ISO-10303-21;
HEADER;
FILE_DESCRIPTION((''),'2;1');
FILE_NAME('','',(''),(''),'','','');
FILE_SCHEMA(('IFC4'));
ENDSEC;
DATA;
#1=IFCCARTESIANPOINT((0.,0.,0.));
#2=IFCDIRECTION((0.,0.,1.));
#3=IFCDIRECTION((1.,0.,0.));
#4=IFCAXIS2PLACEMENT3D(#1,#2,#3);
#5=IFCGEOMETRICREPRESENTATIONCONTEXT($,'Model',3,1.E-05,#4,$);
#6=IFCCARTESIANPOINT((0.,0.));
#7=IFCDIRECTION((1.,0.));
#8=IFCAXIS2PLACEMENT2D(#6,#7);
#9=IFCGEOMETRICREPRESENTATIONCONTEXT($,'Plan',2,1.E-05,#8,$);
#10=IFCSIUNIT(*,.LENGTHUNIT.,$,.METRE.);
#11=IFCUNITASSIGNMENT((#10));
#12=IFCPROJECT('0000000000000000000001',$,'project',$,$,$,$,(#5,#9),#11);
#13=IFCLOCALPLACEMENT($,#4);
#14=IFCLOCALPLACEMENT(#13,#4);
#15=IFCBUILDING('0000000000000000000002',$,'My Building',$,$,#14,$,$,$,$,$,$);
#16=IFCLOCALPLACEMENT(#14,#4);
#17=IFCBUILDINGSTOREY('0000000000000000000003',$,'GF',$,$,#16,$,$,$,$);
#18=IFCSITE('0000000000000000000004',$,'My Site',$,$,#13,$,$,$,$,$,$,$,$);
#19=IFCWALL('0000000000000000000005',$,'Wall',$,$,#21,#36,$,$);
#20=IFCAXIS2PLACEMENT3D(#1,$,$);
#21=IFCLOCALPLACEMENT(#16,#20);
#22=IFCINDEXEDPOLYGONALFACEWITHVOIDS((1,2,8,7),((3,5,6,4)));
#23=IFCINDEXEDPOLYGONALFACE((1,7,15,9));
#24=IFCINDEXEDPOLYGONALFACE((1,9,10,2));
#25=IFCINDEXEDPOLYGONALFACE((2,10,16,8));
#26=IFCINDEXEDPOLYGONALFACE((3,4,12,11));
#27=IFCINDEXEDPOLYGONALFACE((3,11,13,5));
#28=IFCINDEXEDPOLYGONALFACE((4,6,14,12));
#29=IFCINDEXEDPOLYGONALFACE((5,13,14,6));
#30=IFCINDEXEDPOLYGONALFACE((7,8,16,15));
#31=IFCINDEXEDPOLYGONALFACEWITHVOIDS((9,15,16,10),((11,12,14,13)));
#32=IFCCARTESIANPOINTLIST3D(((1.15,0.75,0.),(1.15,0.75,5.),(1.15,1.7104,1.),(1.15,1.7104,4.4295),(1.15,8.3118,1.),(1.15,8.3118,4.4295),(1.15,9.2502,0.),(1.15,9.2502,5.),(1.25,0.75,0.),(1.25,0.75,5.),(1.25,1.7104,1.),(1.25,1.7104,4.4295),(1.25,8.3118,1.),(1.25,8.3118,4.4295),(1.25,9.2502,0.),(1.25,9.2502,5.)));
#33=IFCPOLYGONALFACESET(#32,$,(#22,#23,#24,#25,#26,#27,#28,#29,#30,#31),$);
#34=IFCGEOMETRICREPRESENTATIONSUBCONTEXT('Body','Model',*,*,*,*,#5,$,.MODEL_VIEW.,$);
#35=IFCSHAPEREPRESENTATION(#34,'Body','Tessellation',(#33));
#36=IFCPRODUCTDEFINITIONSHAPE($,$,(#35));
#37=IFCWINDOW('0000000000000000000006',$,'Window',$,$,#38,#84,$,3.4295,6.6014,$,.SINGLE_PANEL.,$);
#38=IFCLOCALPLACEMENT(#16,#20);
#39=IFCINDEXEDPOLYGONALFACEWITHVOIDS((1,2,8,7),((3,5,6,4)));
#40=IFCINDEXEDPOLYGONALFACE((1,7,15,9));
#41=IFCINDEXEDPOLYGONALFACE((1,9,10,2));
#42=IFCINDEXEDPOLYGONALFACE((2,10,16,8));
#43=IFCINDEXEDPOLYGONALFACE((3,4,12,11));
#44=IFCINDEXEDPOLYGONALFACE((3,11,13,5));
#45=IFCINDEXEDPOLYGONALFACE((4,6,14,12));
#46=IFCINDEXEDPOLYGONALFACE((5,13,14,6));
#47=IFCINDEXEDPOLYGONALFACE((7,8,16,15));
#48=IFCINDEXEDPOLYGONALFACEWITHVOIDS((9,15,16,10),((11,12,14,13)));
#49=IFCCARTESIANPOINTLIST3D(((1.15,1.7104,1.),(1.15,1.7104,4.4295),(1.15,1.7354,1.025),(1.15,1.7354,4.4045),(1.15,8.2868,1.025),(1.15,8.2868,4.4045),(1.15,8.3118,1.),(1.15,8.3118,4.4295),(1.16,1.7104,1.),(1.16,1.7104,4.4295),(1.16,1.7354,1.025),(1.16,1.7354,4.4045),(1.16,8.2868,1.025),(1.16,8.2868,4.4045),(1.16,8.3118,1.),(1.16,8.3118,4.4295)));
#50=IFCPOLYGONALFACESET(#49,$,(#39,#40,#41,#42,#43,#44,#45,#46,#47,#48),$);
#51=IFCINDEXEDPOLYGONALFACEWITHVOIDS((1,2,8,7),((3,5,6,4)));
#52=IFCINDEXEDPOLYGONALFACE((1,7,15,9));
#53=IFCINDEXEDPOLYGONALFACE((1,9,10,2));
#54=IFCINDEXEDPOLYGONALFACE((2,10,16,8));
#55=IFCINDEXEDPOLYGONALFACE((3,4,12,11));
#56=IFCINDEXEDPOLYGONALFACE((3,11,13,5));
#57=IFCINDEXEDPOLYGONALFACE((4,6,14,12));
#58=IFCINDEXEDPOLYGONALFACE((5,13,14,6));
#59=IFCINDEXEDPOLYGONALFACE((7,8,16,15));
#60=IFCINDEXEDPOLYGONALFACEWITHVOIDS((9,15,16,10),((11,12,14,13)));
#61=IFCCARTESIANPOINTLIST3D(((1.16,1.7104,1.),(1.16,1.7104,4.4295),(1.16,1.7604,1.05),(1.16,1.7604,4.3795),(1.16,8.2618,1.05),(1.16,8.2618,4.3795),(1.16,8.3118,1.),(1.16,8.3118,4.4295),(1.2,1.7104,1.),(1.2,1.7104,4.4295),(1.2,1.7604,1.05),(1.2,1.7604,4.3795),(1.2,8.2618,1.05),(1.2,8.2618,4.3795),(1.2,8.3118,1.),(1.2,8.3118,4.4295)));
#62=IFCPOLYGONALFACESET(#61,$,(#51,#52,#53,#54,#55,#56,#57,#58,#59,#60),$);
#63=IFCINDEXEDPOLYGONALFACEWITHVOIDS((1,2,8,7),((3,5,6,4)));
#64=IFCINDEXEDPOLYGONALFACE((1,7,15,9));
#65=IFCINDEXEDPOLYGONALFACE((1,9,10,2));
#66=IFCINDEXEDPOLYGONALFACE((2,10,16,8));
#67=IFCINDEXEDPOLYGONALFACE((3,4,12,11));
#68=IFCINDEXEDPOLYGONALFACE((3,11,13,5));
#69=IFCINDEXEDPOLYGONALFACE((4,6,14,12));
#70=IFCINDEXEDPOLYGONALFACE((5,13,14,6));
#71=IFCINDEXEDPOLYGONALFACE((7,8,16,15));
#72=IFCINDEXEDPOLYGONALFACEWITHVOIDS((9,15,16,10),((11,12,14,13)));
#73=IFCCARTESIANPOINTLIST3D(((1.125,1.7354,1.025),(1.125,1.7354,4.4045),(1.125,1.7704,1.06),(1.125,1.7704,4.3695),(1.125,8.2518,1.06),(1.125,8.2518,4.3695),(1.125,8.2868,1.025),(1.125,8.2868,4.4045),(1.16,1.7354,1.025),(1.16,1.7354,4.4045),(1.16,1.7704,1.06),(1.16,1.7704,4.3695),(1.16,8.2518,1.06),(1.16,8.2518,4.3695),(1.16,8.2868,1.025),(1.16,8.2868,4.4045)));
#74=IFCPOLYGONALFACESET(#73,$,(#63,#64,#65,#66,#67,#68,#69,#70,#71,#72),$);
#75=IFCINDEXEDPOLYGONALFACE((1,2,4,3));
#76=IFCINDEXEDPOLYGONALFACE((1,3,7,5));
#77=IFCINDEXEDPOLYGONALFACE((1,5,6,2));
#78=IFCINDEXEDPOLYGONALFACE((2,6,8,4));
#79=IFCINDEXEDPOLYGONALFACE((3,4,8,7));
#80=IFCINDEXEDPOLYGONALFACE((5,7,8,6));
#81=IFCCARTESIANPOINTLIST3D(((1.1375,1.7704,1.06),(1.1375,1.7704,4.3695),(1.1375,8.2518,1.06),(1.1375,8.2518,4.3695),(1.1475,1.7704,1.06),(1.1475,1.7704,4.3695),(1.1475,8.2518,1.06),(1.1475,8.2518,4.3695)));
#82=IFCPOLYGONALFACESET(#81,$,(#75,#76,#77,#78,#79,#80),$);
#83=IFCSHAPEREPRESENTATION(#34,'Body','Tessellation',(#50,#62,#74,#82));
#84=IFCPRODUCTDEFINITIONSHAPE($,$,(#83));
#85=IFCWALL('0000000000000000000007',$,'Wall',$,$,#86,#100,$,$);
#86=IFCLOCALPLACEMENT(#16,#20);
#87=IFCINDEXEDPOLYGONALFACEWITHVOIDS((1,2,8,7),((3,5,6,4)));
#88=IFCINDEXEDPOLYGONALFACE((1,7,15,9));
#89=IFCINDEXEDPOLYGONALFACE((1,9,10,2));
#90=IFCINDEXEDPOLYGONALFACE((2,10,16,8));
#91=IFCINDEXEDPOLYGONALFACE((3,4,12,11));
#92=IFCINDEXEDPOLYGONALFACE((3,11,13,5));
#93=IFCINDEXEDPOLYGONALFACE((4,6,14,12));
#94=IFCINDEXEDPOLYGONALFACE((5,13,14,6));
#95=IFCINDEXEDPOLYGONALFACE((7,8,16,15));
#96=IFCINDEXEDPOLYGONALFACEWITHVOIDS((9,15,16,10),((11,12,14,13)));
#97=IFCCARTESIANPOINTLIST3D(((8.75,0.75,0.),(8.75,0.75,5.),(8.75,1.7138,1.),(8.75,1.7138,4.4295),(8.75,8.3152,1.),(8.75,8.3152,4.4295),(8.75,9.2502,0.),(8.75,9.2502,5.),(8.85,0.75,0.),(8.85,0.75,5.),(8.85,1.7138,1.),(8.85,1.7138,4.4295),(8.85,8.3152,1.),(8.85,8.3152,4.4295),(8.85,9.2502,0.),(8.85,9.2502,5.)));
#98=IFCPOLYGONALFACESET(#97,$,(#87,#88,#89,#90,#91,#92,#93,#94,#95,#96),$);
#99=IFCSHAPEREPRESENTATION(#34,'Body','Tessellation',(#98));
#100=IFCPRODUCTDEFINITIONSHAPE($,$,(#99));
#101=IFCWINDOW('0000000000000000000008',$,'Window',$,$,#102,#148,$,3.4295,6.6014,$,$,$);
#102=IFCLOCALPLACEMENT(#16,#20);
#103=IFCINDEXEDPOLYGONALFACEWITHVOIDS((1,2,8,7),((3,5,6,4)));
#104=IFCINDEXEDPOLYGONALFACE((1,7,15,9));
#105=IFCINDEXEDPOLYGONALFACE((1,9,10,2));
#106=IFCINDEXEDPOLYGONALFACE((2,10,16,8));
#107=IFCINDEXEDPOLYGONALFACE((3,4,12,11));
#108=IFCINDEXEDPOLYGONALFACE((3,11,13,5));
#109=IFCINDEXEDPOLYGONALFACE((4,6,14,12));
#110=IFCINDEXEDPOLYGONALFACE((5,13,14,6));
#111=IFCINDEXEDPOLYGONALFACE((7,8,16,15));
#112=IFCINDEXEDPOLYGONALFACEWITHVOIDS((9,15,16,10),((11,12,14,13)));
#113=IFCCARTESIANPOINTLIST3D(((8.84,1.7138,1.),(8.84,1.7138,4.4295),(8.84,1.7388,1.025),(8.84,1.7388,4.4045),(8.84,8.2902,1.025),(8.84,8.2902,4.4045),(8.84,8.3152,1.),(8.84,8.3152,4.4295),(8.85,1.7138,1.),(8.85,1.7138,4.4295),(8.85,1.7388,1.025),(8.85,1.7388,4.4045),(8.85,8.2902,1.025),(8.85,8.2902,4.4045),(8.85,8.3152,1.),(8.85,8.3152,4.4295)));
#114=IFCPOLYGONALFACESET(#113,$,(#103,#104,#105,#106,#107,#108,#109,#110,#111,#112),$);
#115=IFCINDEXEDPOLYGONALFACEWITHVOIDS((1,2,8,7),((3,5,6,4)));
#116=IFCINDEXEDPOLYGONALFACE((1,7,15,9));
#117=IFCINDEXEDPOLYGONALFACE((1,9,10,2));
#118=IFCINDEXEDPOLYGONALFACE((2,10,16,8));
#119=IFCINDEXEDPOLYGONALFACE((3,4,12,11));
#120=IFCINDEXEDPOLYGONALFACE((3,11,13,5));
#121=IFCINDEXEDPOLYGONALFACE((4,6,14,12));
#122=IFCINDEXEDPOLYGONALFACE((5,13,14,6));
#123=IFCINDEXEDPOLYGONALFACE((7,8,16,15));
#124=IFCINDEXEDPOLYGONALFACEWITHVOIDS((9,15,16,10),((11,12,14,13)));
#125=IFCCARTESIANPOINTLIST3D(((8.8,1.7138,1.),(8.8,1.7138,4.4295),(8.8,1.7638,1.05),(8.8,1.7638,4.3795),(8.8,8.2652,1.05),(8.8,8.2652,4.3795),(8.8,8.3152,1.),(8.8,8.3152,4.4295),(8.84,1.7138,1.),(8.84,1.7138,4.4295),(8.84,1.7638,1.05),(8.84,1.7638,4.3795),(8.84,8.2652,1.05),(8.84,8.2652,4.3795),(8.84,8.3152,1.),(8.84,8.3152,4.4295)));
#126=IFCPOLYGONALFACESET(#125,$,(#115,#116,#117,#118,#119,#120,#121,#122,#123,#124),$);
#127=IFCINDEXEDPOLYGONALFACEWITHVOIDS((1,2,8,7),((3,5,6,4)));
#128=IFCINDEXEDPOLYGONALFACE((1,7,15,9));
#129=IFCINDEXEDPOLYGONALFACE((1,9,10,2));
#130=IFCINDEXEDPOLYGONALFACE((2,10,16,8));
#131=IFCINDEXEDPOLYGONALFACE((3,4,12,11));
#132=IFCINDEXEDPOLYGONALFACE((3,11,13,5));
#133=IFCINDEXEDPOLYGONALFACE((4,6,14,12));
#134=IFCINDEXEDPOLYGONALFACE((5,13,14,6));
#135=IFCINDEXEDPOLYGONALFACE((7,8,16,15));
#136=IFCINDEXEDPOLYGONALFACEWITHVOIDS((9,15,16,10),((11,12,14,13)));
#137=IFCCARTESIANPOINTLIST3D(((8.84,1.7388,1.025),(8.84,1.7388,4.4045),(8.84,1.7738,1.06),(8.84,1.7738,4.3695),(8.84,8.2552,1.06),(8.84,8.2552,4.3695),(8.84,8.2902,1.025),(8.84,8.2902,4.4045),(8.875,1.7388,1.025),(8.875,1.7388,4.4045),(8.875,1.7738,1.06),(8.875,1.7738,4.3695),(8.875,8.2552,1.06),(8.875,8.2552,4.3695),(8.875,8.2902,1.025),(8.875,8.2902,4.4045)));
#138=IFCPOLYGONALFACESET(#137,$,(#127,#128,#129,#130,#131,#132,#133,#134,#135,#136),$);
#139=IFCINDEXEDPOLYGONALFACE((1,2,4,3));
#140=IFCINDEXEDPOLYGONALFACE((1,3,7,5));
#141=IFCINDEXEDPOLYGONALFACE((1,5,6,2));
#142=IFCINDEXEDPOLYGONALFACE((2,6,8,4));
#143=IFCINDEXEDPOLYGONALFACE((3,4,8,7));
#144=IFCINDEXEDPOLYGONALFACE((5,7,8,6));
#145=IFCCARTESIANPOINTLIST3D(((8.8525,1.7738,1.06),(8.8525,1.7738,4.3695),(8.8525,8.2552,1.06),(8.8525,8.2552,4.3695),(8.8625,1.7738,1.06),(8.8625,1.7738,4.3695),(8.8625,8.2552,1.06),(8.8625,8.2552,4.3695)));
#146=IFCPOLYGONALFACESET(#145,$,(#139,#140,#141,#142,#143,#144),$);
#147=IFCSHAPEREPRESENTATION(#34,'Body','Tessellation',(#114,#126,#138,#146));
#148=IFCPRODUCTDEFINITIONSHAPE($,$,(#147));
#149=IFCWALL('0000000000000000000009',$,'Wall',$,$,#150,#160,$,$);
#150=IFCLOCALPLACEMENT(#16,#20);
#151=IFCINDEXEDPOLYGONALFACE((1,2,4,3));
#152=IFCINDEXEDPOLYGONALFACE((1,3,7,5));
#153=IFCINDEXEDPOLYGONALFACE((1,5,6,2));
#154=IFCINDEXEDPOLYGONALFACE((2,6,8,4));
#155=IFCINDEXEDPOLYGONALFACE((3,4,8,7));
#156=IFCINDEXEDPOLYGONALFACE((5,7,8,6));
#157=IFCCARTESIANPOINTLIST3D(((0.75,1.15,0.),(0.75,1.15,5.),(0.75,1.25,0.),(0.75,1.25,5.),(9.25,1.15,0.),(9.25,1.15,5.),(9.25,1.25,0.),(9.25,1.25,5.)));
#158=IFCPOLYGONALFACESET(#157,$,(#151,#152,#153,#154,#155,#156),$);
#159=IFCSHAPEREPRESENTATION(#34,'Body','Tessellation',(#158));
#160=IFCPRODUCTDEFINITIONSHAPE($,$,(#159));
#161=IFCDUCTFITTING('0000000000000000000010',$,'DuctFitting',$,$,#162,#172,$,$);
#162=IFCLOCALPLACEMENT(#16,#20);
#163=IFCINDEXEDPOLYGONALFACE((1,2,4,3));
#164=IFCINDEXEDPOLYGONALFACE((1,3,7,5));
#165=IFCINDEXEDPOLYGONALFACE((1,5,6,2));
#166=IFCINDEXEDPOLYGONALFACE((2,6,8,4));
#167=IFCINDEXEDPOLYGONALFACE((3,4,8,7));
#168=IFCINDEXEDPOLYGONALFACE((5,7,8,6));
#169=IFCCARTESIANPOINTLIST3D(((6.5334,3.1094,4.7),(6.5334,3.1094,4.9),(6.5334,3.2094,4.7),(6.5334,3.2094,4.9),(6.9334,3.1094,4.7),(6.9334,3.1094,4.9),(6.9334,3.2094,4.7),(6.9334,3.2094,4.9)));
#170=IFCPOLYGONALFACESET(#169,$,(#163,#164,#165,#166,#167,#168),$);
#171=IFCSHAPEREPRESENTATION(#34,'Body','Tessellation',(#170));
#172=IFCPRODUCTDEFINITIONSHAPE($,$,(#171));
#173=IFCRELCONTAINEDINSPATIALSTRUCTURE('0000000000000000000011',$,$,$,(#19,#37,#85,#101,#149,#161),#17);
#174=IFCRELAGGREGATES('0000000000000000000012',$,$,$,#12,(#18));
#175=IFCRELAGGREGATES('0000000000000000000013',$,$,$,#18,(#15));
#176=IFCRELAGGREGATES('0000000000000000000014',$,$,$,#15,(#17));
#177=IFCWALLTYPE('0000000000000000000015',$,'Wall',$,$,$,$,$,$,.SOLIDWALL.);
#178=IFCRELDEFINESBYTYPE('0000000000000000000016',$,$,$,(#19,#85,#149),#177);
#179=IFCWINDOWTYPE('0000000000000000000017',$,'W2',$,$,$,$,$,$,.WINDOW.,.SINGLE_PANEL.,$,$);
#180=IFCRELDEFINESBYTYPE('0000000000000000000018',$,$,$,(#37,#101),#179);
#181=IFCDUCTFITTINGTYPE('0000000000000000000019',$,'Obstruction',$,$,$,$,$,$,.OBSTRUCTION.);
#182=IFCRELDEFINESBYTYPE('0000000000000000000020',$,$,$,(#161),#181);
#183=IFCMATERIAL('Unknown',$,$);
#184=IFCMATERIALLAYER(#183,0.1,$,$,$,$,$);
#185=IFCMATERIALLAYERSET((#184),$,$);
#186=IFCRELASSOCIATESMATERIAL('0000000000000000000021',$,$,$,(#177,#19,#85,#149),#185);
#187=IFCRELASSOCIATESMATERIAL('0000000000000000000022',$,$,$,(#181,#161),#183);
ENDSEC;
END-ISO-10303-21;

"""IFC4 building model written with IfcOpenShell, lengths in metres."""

from ifc_helpers import new_model, entity, si_unit, frame, origin_with_axes, origin_2d_with_axis, place, context, subcontext, project, spatial, line, indexed_curve, rectangle, outline, extrude, shape, source, transform, mapped, material, layer, layer_set, layer_usage, material_profile, profile_set, profile_usage, type_object, type_shapes, element, fill, save


model = new_model("IFC4")

# Units and contexts
model_context = context("Model", 3, precision=1e-05, world=origin_with_axes())
plan_context = context("Plan", 2, precision=1e-05, world=origin_2d_with_axis())
body_context_1 = subcontext(model_context, "Body", "Model", "MODEL_VIEW")
body_context_2 = subcontext(plan_context, "Body", "Plan", "PLAN_VIEW")
ifc_project = project(units=[si_unit("LENGTHUNIT", "METRE")], contexts=[model_context, plan_context])

# Site, building, storey
site_placement = place(None, origin_with_axes())
site = spatial("IfcSite", under=ifc_project, at=site_placement, Name="My Site")
building_placement = place(site_placement, origin_with_axes())
building = spatial("IfcBuilding", under=site, at=building_placement, Name="My Building")
storey_placement = place(building_placement, origin_with_axes())
storey = spatial("IfcBuildingStorey", under=building, at=storey_placement, Name="GF")

# Shared definitions
ifc_material = material(Name="Unknown")

# Wall, opening, window
ifc_layer_1 = layer(ifc_material, 0.1)
ifc_layer_set_1 = layer_set([ifc_layer_1])
ifc_layer_usage_1 = layer_usage(ifc_layer_set_1, "AXIS2", "POSITIVE", 0.0)
wall_type = type_object("IfcWallType", Name="Wall", PredefinedType="SOLIDWALL", material=ifc_layer_set_1)
wall_1_placement = place(storey_placement, frame((1.15, 9.2502, 0.0), z_axis=(0.0, 0.0, 1.0), x_axis=(0.0, -1.0, 0.0)))
wall_1 = element("IfcWall", 1, at=wall_1_placement, inside=storey, type_object=wall_type, material=ifc_layer_usage_1, Name="Wall", context=body_context_1, shape_type="SweptSolid", body=[
    extrude(outline(indexed_curve([(0.0, 0.0), (0.0, 0.1), (8.5002, 0.1), (8.5002, 0.0)], segments=[line(1, 2, 3, 4, 1)])), origin_with_axes(), (0.0, 0.0, 1.0), 5.0),
])
shared_shape_1 = source(origin_with_axes(), body_context_1, "Body", "SweptSolid", [
    extrude(outline(indexed_curve([(0.0, 0.0), (6.6014, 0.0), (6.6014, 3.4295), (0.0, 3.4295)], segments=[line(1, 2, 3, 4, 1)])), frame((0.0, -0.6, 0.0), z_axis=(0.0, -1.0, 0.0), x_axis=(1.0, 0.0, 0.0)), (0.0, 0.0, -1.0), 1.2),
])
opening_1_placement = place(wall_1_placement, frame((7.5398, 0.1, 1.0), z_axis=(0.0, 0.0, 1.0), x_axis=(-1.0, 0.0, 0.0)))
opening_1 = element("IfcOpeningElement", 2, at=opening_1_placement, cuts=wall_1, PredefinedType="OPENING", context=body_context_1, shape_type="MappedRepresentation", body=[
    mapped(shared_shape_1, transform((0.0, 0.0, 0.0), x_axis=(1.0, 0.0, 0.0), y_axis=(0.0, 1.0, 0.0), z_axis=(0.0, 0.0, 1.0), scale=1.0)),
])
window_type_1 = type_object("IfcWindowType", Name="W2", PartitioningType="SINGLE_PANEL", PredefinedType="WINDOW")
shared_shape_2 = source(origin_with_axes(), body_context_1, "Body", "SweptSolid", [
    extrude(outline(indexed_curve([(0.0, 0.0), (6.6014, 0.0), (6.6014, 3.4295), (0.0, 3.4295)], segments=[line(1, 2, 3, 4, 1)]), holes=[indexed_curve([(0.025, 0.025), (6.5764, 0.025), (6.5764, 3.4045), (0.025, 3.4045)], segments=[line(1, 2, 3, 4, 1)])]), frame((0.0, 0.09, 0.0), z_axis=(0.0, -1.0, 0.0), x_axis=(1.0, 0.0, 0.0)), (0.0, 0.0, -1.0), 0.01),
    extrude(outline(indexed_curve([(0.0, 0.0), (6.6014, 0.0), (6.6014, 3.4295), (0.0, 3.4295)], segments=[line(1, 2, 3, 4, 1)]), holes=[indexed_curve([(0.05, 0.05), (6.5514, 0.05), (6.5514, 3.3795), (0.05, 3.3795)], segments=[line(1, 2, 3, 4, 1)])]), frame((0.0, 0.05, 0.0), z_axis=(0.0, -1.0, 0.0), x_axis=(1.0, 0.0, 0.0)), (0.0, 0.0, -1.0), 0.04),
    extrude(outline(indexed_curve([(0.0, 0.0), (6.5514, 0.0), (6.5514, 3.3795), (0.0, 3.3795)], segments=[line(1, 2, 3, 4, 1)]), holes=[indexed_curve([(0.035, 0.035), (6.5164, 0.035), (6.5164, 3.3445), (0.035, 3.3445)], segments=[line(1, 2, 3, 4, 1)])]), frame((0.025, 0.09, 0.025), z_axis=(0.0, -1.0, 0.0), x_axis=(1.0, 0.0, 0.0)), (0.0, 0.0, -1.0), 0.035),
    extrude(outline(indexed_curve([(0.035, 0.035), (6.5164, 0.035), (6.5164, 3.3445), (0.035, 3.3445)], segments=[line(1, 2, 3, 4, 1)])), frame((0.025, 0.1025, 0.025), z_axis=(0.0, -1.0, 0.0), x_axis=(1.0, 0.0, 0.0)), (0.0, 0.0, -1.0), 0.01),
])
shared_shape_3 = source(origin_with_axes(), body_context_2, "Body", "Curve2D", [
    entity("IfcIndexedPolyCurve", entity("IfcCartesianPointList2D", [[0.05, 0.05], [6.5514, 0.05]])),
    entity("IfcIndexedPolyCurve", entity("IfcCartesianPointList2D", [[0.0, 0.1], [0.025, 0.1], [0.025, 0.09], [0.05, 0.09], [0.05, 0.05], [0.0, 0.05]]), [entity("IfcLineIndex", [1, 2, 3, 4, 5, 6, 1])]),
    entity("IfcIndexedPolyCurve", entity("IfcCartesianPointList2D", [[6.6014, 0.1], [6.5764, 0.1], [6.5764, 0.09], [6.5514, 0.09], [6.5514, 0.05], [6.6014, 0.05]]), [entity("IfcLineIndex", [1, 2, 3, 4, 5, 6, 1])]),
    entity("IfcIndexedPolyCurve", entity("IfcCartesianPointList2D", [[0.025, 0.09], [0.06, 0.09], [0.06, 0.125], [0.025, 0.125]]), [entity("IfcLineIndex", [1, 2, 3, 4, 1])]),
    entity("IfcIndexedPolyCurve", entity("IfcCartesianPointList2D", [[6.5764, 0.09], [6.5414, 0.09], [6.5414, 0.125], [6.5764, 0.125]]), [entity("IfcLineIndex", [1, 2, 3, 4, 1])]),
    entity("IfcIndexedPolyCurve", entity("IfcCartesianPointList2D", [[0.06, 0.09], [6.5414, 0.09]])),
    entity("IfcIndexedPolyCurve", entity("IfcCartesianPointList2D", [[0.06, 0.125], [6.5414, 0.125]])),
    entity("IfcIndexedPolyCurve", entity("IfcCartesianPointList2D", [[0.06, 0.1075], [6.5414, 0.1075]])),
])
type_shapes(window_type_1, [shared_shape_2, shared_shape_3])
window_1_placement = place(opening_1_placement, frame((0.0, 0.0, 0.0), z_axis=(0.0, 0.0, 1.0), x_axis=(1.0, 0.0, 0.0)))
window_1 = element("IfcWindow", 3, at=window_1_placement, inside=storey, type_object=window_type_1, Name="Window", OverallHeight=3.4295, OverallWidth=6.6014, PartitioningType="SINGLE_PANEL", shapes=[
    shape(body_context_1, "Body", "MappedRepresentation", [mapped(shared_shape_2, transform((0.0, 0.0, 0.0), x_axis=(1.0, 0.0, 0.0), y_axis=(0.0, 1.0, 0.0), z_axis=(0.0, 0.0, 1.0), scale=1.0))]),
    shape(body_context_2, "Body", "MappedRepresentation", [mapped(shared_shape_3, transform((0.0, 0.0, 0.0), x_axis=(1.0, 0.0, 0.0), y_axis=(0.0, 1.0, 0.0), z_axis=(0.0, 0.0, 1.0), scale=1.0))]),
])
fill(opening_1, window_1)

# Wall, opening, window
ifc_layer_usage_2 = layer_usage(ifc_layer_set_1, "AXIS2", "POSITIVE", 0.0)
wall_2_placement = place(storey_placement, frame((8.75, 9.2502, 0.0), z_axis=(0.0, 0.0, 1.0), x_axis=(0.0, -1.0, 0.0)))
wall_2 = element("IfcWall", 4, at=wall_2_placement, inside=storey, type_object=wall_type, material=ifc_layer_usage_2, Name="Wall", context=body_context_1, shape_type="SweptSolid", body=[
    extrude(outline(indexed_curve([(0.0, 0.0), (0.0, 0.1), (8.5002, 0.1), (8.5002, 0.0)], segments=[line(1, 2, 3, 4, 1)])), origin_with_axes(), (0.0, 0.0, 1.0), 5.0),
])
opening_2_placement = place(wall_2_placement, frame((0.935, 0.0, 1.0), z_axis=(0.0, 0.0, 1.0), x_axis=(1.0, 0.0, 0.0)))
opening_2 = element("IfcOpeningElement", 5, at=opening_2_placement, cuts=wall_2, PredefinedType="OPENING", context=body_context_1, shape_type="MappedRepresentation", body=[
    mapped(shared_shape_1, transform((0.0, 0.0, 0.0), x_axis=(1.0, 0.0, 0.0), y_axis=(0.0, 1.0, 0.0), z_axis=(0.0, 0.0, 1.0), scale=1.0)),
])
window_2_placement = place(opening_2_placement, frame((0.0, 0.0, 0.0), z_axis=(0.0, 0.0, 1.0), x_axis=(1.0, 0.0, 0.0)))
window_2 = element("IfcWindow", 6, at=window_2_placement, inside=storey, type_object=window_type_1, Name="Window", OverallHeight=3.4295, OverallWidth=6.6014, shapes=[
    shape(body_context_1, "Body", "MappedRepresentation", [mapped(shared_shape_2, transform((0.0, 0.0, 0.0), x_axis=(1.0, 0.0, 0.0), y_axis=(0.0, 1.0, 0.0), z_axis=(0.0, 0.0, 1.0), scale=1.0))]),
    shape(body_context_2, "Body", "MappedRepresentation", [mapped(shared_shape_3, transform((0.0, 0.0, 0.0), x_axis=(1.0, 0.0, 0.0), y_axis=(0.0, 1.0, 0.0), z_axis=(0.0, 0.0, 1.0), scale=1.0))]),
])
fill(opening_2, window_2)

# Wall
ifc_layer_usage_3 = layer_usage(ifc_layer_set_1, "AXIS2", "POSITIVE", 0.0)
wall_3_placement = place(storey_placement, frame((0.75, 1.15, 0.0), z_axis=(0.0, 0.0, 1.0), x_axis=(1.0, 0.0, 0.0)))
element("IfcWall", 7, at=wall_3_placement, inside=storey, type_object=wall_type, material=ifc_layer_usage_3, Name="Wall", context=body_context_1, shape_type="SweptSolid", body=[
    extrude(outline(indexed_curve([(0.0, 0.0), (0.0, 0.1), (8.5, 0.1), (8.5, 0.0)], segments=[line(1, 2, 3, 4, 1)])), origin_with_axes(), (0.0, 0.0, 1.0), 5.0),
])

# Duct fitting
ifc_material_profile_1 = material_profile(ifc_material, rectangle(XDim=0.4, YDim=0.2))
ifc_profile_set_1 = profile_set([ifc_material_profile_1])
ifc_profile_usage_1 = profile_usage(ifc_profile_set_1, cardinal=5)
duct_fitting_type = type_object("IfcDuctFittingType", Name="Obstruction", PredefinedType="OBSTRUCTION", material=ifc_profile_set_1)
duct_fitting_1_placement = place(storey_placement, frame((6.7334, 3.2094, 4.8), z_axis=(0.0, -1.0, 0.0), x_axis=(1.0, 0.0, 0.0)))
element("IfcDuctFitting", 8, at=duct_fitting_1_placement, inside=storey, type_object=duct_fitting_type, material=ifc_profile_usage_1, Name="DuctFitting", context=body_context_1, shape_type="SweptSolid", body=[
    extrude(rectangle(XDim=0.4, YDim=0.2), origin_with_axes(), (0.0, 0.0, 1.0), 0.1),
])

save(model, "model.ifc")
